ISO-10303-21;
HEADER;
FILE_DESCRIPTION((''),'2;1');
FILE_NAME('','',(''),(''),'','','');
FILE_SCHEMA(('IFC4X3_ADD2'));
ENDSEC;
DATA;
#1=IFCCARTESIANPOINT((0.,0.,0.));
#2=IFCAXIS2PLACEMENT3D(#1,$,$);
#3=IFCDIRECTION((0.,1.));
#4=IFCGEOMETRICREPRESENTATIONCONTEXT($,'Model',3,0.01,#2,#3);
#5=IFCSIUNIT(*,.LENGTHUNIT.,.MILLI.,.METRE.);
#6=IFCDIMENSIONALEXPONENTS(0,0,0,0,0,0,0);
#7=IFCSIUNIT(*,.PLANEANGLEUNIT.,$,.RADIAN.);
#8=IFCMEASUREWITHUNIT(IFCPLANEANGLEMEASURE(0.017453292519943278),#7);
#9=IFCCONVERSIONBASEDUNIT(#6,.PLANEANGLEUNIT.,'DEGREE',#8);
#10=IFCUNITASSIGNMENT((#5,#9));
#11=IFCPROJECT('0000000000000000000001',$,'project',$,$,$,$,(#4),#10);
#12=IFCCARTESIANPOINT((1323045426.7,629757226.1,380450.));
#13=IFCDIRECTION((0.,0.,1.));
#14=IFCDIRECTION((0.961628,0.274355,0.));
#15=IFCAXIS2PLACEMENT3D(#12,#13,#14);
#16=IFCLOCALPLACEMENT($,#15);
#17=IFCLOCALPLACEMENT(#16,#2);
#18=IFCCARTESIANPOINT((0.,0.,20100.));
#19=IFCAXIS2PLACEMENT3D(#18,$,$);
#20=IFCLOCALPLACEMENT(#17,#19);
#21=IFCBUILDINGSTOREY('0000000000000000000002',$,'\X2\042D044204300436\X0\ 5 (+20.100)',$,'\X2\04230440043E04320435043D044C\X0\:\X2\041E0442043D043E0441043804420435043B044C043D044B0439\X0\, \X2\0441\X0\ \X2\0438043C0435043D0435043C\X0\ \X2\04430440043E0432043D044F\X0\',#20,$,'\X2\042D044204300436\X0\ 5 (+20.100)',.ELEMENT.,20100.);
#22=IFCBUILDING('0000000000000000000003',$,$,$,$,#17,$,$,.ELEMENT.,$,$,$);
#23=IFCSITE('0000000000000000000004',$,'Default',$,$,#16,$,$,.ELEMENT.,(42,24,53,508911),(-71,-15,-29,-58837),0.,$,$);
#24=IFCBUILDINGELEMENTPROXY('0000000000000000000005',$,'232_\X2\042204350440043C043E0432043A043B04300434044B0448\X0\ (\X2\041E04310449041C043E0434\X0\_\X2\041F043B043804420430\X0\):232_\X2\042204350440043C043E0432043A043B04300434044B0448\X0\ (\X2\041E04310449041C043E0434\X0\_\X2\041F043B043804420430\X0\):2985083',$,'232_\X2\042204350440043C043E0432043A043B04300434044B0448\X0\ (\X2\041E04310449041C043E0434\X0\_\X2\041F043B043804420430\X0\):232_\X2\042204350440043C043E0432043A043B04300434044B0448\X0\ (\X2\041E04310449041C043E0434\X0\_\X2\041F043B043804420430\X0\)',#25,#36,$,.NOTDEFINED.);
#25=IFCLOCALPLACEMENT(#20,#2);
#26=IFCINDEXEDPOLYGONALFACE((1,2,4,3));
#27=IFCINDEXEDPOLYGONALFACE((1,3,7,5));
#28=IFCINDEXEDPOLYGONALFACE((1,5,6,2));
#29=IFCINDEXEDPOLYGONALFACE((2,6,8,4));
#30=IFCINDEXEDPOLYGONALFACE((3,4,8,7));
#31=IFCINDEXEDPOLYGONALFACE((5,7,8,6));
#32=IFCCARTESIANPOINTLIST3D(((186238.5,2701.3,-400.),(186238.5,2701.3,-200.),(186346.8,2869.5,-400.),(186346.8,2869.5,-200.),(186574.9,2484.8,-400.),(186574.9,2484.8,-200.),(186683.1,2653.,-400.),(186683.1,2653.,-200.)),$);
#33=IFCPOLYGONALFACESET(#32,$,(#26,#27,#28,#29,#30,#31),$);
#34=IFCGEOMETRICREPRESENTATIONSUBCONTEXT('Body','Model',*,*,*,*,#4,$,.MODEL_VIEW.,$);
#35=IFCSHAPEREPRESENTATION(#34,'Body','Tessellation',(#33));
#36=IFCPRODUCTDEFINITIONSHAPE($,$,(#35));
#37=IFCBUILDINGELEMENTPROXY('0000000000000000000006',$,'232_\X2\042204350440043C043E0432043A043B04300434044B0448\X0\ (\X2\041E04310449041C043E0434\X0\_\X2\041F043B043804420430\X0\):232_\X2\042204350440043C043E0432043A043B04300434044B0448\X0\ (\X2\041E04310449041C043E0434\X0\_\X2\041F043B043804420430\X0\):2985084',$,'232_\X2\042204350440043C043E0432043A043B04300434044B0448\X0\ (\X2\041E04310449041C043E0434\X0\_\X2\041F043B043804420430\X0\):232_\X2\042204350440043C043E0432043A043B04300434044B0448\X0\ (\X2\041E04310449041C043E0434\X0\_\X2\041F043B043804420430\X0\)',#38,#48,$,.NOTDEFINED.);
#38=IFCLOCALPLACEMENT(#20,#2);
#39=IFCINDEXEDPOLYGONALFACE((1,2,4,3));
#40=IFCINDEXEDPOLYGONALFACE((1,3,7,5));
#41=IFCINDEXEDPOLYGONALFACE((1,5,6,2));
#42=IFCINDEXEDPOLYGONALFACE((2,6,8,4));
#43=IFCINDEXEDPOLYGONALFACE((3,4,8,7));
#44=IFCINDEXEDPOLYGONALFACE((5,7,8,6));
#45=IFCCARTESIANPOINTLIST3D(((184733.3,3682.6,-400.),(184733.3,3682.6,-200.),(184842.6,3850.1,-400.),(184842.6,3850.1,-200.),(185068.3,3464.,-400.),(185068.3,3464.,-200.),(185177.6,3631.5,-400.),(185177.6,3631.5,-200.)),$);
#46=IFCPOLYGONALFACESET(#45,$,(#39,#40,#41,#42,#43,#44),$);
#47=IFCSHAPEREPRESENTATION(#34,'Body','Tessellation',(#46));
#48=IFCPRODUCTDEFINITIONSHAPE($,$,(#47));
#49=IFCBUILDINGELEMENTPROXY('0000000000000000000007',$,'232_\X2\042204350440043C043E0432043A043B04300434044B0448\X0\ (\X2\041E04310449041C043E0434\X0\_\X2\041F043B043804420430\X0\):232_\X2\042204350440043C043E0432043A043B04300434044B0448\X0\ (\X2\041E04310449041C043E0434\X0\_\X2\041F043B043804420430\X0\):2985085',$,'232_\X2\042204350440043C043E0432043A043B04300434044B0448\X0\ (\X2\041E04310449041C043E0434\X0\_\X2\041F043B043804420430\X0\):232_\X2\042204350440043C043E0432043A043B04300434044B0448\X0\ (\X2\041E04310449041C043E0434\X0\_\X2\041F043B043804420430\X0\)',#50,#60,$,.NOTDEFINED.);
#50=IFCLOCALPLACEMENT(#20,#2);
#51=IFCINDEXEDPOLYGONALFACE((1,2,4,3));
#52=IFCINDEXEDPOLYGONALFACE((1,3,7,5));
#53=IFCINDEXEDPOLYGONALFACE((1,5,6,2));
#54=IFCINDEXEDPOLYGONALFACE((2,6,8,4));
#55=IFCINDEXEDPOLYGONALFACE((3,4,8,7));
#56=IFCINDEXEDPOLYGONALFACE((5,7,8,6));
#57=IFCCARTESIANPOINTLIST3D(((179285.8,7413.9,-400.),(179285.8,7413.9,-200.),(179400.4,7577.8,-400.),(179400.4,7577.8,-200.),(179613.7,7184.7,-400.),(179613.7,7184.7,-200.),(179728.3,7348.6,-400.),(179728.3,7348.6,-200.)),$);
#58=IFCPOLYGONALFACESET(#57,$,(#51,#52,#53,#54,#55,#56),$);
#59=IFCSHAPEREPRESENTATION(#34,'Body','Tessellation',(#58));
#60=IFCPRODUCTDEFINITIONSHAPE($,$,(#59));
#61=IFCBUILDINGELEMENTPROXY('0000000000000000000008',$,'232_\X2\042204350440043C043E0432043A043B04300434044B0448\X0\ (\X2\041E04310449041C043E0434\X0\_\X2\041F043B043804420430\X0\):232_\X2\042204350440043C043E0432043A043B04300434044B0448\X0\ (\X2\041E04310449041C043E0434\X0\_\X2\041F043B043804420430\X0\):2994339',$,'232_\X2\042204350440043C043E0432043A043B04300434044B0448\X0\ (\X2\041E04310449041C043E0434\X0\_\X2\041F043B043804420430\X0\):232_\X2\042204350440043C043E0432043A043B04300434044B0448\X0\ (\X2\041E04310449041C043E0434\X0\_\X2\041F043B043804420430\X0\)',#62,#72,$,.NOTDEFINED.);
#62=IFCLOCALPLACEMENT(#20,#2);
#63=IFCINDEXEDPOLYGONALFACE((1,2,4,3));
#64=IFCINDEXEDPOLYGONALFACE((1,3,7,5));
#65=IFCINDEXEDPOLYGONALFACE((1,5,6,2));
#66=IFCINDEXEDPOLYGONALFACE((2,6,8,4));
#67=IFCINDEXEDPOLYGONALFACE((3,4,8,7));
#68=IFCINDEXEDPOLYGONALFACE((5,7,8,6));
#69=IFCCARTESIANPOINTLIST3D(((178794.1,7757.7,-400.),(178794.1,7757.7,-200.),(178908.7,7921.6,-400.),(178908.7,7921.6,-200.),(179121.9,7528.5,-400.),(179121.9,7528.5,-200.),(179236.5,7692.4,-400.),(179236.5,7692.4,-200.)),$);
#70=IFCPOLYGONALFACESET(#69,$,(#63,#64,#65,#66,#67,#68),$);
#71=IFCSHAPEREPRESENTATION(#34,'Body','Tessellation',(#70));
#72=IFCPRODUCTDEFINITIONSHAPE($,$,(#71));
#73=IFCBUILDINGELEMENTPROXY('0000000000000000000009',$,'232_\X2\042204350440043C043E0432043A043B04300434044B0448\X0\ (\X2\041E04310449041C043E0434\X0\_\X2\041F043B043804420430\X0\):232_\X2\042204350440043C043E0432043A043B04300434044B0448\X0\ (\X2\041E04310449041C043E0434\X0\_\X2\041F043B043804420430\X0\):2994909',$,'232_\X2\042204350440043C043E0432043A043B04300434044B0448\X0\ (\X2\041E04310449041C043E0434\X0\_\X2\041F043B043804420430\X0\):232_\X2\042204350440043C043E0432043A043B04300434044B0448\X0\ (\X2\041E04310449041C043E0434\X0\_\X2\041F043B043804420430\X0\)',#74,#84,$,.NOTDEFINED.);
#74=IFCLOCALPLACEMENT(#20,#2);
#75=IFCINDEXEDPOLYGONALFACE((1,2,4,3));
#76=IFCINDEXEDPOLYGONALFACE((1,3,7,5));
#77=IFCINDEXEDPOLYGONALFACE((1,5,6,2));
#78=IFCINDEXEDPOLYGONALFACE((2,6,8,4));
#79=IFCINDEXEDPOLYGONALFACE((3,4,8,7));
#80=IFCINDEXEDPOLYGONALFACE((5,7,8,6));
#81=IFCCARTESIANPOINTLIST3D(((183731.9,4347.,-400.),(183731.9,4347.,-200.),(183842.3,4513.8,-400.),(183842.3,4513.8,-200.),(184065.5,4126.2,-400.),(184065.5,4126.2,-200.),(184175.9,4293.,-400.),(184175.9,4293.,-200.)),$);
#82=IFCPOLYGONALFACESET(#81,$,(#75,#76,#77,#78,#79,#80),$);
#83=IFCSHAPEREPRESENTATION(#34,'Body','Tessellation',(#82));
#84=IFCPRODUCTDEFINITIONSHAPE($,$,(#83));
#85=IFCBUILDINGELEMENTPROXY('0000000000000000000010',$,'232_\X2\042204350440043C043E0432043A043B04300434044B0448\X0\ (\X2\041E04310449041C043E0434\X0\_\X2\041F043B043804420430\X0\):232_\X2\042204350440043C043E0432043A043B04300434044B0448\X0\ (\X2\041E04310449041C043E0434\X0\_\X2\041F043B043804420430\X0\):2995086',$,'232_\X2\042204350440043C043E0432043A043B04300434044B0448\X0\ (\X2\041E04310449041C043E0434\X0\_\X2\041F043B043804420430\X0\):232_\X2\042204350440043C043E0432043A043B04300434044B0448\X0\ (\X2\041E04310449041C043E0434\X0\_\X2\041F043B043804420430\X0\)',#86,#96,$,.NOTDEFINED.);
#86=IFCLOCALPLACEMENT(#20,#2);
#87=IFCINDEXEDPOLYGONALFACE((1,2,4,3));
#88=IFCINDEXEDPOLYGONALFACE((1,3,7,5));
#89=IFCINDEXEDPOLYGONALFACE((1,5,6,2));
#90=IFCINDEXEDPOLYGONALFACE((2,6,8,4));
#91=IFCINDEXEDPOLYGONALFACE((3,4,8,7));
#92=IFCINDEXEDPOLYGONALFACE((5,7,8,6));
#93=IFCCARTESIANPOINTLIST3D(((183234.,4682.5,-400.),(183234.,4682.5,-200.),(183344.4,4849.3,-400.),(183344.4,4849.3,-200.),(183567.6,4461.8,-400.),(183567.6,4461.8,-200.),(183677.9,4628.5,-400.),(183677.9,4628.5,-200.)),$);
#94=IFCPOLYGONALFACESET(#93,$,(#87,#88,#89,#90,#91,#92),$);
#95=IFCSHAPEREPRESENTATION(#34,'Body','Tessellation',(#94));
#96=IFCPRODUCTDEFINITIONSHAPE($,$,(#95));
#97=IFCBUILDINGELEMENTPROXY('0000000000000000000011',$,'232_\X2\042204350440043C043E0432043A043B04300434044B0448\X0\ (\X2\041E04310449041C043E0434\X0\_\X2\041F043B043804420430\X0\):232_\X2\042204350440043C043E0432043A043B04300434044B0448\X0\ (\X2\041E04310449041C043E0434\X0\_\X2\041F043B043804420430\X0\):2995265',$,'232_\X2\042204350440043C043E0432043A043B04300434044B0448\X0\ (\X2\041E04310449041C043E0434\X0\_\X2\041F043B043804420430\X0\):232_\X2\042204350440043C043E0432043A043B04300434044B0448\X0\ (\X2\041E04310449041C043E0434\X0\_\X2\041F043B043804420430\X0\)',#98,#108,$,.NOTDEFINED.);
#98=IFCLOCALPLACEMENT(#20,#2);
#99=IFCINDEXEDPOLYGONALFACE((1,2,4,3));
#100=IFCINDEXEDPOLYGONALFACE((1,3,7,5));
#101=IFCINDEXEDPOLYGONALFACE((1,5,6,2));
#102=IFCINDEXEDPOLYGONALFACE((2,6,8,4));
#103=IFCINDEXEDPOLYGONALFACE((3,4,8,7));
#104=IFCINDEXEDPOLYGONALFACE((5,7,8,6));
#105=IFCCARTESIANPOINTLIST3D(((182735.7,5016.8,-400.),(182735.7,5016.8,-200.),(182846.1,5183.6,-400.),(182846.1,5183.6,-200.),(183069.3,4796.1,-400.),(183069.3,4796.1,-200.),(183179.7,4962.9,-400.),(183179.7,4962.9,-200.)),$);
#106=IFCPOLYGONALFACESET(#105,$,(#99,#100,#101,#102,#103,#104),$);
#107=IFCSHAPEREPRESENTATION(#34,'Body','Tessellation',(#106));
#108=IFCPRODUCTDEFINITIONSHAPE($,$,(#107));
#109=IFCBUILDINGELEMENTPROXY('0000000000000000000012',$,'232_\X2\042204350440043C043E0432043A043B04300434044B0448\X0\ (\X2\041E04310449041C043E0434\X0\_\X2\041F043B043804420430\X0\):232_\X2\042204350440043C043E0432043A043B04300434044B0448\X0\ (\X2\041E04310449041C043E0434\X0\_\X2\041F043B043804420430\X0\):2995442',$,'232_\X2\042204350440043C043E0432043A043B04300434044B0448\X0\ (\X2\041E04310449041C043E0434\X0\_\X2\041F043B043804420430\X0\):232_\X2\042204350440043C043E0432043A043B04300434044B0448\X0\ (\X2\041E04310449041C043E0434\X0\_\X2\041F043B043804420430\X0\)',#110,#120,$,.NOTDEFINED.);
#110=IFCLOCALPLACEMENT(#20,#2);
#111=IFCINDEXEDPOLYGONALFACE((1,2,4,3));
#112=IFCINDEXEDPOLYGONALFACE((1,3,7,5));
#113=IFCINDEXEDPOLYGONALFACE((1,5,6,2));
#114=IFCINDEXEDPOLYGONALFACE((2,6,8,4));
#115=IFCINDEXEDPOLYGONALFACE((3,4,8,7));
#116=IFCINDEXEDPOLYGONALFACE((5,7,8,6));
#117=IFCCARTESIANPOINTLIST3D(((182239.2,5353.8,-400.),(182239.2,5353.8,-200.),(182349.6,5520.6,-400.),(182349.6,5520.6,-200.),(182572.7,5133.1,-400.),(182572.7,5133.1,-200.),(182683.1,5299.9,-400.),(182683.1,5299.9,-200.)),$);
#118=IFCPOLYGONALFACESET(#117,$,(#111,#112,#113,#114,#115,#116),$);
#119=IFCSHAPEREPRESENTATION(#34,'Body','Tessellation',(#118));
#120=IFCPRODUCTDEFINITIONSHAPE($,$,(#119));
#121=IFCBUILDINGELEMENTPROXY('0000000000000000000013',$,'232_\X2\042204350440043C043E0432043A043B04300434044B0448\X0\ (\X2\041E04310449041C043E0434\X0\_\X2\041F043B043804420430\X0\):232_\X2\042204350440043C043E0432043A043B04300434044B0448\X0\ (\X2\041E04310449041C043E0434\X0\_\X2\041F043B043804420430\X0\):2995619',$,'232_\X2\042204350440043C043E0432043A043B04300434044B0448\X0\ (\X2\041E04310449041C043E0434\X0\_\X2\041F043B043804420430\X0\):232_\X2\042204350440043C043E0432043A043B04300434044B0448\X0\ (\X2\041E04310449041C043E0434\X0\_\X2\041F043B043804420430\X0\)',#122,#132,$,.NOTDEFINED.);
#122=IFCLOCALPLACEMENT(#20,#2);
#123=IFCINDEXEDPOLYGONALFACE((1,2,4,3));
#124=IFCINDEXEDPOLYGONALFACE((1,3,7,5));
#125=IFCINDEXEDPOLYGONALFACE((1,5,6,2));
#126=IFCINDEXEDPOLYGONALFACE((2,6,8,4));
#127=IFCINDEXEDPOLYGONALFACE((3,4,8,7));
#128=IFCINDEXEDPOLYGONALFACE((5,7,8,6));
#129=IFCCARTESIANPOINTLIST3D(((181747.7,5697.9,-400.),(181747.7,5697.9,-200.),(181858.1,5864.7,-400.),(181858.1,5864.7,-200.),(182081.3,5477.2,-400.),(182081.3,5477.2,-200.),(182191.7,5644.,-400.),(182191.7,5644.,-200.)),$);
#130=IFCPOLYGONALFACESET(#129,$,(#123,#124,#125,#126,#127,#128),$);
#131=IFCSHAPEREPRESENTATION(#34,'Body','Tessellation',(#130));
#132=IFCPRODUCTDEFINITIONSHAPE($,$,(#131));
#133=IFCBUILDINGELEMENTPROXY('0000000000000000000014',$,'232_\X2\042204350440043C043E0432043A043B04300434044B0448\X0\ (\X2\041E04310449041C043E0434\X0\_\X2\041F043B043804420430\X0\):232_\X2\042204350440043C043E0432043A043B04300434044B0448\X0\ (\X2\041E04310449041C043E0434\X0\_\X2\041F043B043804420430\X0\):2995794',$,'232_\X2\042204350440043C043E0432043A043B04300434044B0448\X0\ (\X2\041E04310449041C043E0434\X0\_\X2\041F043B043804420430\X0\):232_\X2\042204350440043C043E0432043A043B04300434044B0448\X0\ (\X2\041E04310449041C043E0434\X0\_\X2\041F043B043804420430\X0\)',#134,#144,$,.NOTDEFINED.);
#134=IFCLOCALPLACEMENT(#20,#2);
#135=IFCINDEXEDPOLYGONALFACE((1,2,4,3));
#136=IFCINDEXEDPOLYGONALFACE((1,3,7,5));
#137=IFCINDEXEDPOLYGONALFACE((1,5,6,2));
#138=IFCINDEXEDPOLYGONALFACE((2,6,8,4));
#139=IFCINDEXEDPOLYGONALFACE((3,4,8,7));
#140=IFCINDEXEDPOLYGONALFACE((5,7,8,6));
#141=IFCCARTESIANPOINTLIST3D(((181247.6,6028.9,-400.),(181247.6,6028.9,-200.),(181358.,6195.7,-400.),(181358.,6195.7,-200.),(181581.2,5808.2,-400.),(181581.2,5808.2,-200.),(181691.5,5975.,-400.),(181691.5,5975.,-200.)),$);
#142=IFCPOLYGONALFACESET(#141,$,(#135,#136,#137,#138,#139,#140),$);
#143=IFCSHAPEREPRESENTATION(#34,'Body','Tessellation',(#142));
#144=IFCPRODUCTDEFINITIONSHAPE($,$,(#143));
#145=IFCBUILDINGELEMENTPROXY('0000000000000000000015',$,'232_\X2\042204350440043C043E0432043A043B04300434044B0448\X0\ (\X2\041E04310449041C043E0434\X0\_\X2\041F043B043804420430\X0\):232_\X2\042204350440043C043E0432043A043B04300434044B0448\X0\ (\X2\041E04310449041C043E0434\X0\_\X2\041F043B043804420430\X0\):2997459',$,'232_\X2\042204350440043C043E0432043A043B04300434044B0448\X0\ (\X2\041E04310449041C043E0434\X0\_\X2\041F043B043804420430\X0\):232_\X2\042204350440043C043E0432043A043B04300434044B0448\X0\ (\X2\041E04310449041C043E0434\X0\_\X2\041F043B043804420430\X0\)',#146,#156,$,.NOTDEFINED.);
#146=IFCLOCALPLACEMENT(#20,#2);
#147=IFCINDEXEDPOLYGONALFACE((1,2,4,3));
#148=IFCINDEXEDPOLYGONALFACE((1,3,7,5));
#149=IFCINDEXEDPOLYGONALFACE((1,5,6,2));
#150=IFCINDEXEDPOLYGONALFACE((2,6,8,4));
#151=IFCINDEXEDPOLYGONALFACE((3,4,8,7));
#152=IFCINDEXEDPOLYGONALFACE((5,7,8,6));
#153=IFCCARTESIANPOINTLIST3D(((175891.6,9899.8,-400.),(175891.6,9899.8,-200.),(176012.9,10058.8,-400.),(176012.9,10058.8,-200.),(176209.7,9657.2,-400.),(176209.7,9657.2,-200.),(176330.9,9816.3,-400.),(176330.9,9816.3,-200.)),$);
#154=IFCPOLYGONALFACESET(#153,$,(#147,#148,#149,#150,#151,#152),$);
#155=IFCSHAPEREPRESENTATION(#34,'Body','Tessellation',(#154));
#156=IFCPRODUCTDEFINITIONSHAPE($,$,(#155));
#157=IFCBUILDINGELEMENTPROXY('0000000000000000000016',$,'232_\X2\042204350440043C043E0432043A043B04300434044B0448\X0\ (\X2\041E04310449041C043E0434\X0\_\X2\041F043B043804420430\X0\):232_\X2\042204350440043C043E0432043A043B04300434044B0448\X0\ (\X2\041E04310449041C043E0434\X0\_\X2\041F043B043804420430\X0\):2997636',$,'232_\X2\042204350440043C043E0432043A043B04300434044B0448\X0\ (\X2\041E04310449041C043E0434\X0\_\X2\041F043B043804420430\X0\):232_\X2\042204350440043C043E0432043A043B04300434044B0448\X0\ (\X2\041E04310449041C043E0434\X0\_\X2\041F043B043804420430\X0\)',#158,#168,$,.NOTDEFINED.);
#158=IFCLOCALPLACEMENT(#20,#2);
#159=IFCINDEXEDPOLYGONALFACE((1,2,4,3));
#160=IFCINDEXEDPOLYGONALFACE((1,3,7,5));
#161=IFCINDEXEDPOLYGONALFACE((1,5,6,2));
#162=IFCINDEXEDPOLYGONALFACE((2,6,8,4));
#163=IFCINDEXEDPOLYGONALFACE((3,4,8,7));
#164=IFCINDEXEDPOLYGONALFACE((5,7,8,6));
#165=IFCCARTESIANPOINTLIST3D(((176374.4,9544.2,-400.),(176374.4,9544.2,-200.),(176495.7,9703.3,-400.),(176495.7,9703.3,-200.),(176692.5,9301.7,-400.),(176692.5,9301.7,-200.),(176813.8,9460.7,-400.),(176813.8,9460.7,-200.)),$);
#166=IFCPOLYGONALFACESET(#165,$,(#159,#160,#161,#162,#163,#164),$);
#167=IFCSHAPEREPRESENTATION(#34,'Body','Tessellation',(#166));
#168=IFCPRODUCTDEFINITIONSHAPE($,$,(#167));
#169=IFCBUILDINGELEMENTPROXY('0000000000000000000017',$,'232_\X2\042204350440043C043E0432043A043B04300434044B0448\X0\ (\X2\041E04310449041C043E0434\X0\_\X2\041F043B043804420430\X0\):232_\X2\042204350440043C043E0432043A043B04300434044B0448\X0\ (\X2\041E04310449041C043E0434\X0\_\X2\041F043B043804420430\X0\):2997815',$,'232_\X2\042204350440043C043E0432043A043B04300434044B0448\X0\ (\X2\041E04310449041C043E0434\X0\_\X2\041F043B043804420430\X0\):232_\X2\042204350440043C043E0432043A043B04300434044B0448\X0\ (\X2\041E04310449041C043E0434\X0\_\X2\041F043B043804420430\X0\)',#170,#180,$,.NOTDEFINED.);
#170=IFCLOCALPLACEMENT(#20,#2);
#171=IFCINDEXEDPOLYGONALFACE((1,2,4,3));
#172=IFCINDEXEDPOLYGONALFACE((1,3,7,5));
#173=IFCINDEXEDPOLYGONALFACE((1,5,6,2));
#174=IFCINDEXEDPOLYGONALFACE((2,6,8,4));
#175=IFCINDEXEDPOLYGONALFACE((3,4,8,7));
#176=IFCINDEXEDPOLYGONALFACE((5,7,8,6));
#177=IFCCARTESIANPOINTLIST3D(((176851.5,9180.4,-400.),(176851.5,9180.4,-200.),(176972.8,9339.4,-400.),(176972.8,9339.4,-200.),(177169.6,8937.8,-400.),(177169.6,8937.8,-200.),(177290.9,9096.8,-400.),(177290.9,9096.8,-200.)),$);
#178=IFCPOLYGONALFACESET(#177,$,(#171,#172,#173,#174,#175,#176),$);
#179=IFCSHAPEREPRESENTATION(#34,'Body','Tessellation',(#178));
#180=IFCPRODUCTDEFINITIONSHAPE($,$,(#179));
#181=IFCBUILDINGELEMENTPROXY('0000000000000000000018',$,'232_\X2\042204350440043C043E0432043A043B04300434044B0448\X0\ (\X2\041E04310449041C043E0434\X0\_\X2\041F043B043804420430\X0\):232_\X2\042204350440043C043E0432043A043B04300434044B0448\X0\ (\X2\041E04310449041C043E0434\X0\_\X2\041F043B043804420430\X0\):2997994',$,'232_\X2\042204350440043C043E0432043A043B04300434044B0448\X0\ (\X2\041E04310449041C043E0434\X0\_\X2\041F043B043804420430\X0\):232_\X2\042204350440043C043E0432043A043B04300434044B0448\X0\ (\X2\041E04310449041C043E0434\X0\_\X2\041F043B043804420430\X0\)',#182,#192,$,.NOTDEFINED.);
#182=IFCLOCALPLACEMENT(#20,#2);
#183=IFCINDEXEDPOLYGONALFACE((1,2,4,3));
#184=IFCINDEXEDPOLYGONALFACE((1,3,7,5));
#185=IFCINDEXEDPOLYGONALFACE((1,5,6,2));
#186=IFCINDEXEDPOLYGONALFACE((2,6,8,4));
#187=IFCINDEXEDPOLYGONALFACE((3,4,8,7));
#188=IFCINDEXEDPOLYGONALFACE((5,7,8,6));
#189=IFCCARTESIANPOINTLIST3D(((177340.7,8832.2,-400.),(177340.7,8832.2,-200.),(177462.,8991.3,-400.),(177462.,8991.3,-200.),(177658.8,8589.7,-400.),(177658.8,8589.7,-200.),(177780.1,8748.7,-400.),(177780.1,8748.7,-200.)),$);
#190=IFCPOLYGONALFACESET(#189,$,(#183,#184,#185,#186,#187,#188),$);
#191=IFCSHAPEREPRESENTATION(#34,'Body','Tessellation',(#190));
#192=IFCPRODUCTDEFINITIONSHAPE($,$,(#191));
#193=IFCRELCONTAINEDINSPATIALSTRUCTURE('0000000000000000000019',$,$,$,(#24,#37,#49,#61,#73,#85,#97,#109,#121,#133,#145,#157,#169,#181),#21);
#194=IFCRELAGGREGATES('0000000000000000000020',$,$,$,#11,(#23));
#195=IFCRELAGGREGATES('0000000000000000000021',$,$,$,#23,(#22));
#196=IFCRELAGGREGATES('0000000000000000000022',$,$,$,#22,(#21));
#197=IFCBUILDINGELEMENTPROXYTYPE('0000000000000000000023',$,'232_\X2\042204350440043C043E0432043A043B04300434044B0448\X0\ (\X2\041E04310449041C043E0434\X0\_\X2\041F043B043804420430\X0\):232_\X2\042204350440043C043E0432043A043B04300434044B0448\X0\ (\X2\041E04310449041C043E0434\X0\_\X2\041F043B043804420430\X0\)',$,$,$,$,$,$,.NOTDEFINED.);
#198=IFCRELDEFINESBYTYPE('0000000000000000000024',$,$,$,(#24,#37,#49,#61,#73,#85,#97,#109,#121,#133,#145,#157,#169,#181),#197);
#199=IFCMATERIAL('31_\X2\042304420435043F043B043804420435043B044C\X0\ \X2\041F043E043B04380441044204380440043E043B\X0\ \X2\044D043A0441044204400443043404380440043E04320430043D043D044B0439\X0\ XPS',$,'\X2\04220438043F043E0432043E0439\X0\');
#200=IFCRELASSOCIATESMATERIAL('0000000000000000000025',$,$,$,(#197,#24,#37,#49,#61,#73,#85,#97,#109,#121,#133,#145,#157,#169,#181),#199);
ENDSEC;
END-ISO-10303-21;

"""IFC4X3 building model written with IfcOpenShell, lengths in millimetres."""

from ifc_helpers import new_model, entity, si_unit, converted_unit, direction, frame, origin, origin_2d_with_axis, place, context, subcontext, project, spatial, rectangle, extrude, source, transform, mapped, material, type_object, type_shapes, element, save


model = new_model("IFC4X3")

# Units and contexts
model_context = context("Model", 3, precision=0.01, world=origin(), true_north=direction((0.0, 1.0)))
body_context = subcontext(model_context, "Body", "Model", "MODEL_VIEW")
ifc_project = project(units=[si_unit("LENGTHUNIT", "METRE", prefix="MILLI"), converted_unit("PLANEANGLEUNIT", "DEGREE", entity("IfcPlaneAngleMeasure", 0.017453292519943278), si_unit("PLANEANGLEUNIT", "RADIAN"), dimensions=[0, 0, 0, 0, 0, 0, 0])], contexts=[model_context])

# Site, building, storey
site_placement = place(None, frame((1323045426.7, 629757226.1, 380450.0), z_axis=(0.0, 0.0, 1.0), x_axis=(0.961628, 0.274355, 0.0)))
site = spatial("IfcSite", under=ifc_project, at=site_placement, Name="Default", CompositionType="ELEMENT", RefLatitude=(42, 24, 53, 508911), RefLongitude=(-71, -15, -29, -58837), RefElevation=0.0)
building_placement = place(site_placement, origin())
building = spatial("IfcBuilding", under=site, at=building_placement, CompositionType="ELEMENT")
storey_placement = place(building_placement, frame((0.0, 0.0, 20100.0)))
storey = spatial("IfcBuildingStorey", under=building, at=storey_placement, Name="Этаж 5 (+20.100)", ObjectType="Уровень:Относительный, с именем уровня", LongName="Этаж 5 (+20.100)", CompositionType="ELEMENT", Elevation=20100.0)

# Building element proxies
ifc_material = material(Name="31_Утеплитель Полистирол экструдированный XPS", Category="Типовой")
building_element_proxy_type_1 = type_object("IfcBuildingElementProxyType", Name="232_Термовкладыш (ОбщМод_Плита):232_Термовкладыш (ОбщМод_Плита)", PredefinedType="NOTDEFINED", material=ifc_material)
shared_shape_1 = source(origin(), body_context, "Body", "SweptSolid", [
    extrude(rectangle(XDim=400.0, YDim=200.0, at=origin_2d_with_axis()), frame((200.0, 0.0, -200.0), z_axis=(0.0, 0.0, 1.0), x_axis=(-1.0, 0.0, 0.0)), (0.0, 0.0, 1.0), 200.0),
])
type_shapes(building_element_proxy_type_1, [shared_shape_1])
for number, where, z_axis, x_axis, name in (
    (1, (186629.0, 2568.9, -200.0), (0.0, 0.0, 1.0), (-0.840884, 0.541216, 0.0), "232_Термовкладыш (ОбщМод_Плита):232_Термовкладыш (ОбщМод_Плита):2985083"),
    (2, (185122.9, 3547.7, -200.0), (0.0, 0.0, 1.0), (-0.837417, 0.546565, 0.0), "232_Термовкладыш (ОбщМод_Плита):232_Термовкладыш (ОбщМод_Плита):2985084"),
    (3, (179671.0, 7266.7, -200.0), (0.0, 0.0, 1.0), (-0.819574, 0.572973, 0.0), "232_Термовкладыш (ОбщМод_Плита):232_Термовкладыш (ОбщМод_Плита):2985085"),
    (4, (179179.2, 7610.4, -200.0), (0.0, 0.0, 1.0), (-0.819574, 0.572973, 0.0), "232_Термовкладыш (ОбщМод_Плита):232_Термовкладыш (ОбщМод_Плита):2994339"),
    (5, (184120.7, 4209.6, -200.0), (0.0, 0.0, 1.0), (-0.833916, 0.551892, 0.0), "232_Термовкладыш (ОбщМод_Плита):232_Термовкладыш (ОбщМод_Плита):2994909"),
    (6, (183622.7, 4545.1, -200.0), (0.0, 0.0, 1.0), (-0.833916, 0.551892, 0.0), "232_Термовкладыш (ОбщМод_Плита):232_Термовкладыш (ОбщМод_Плита):2995086"),
    (7, (183124.5, 4879.5, -200.0), (0.0, 0.0, 1.0), (-0.833916, 0.551892, 0.0), "232_Термовкладыш (ОбщМод_Плита):232_Термовкладыш (ОбщМод_Плита):2995265"),
    (8, (182627.9, 5216.5, -200.0), (0.0, 0.0, 1.0), (-0.833916, 0.551892, 0.0), "232_Термовкладыш (ОбщМод_Плита):232_Термовкладыш (ОбщМод_Плита):2995442"),
    (9, (182136.5, 5560.6, -200.0), (0.0, 0.0, 1.0), (-0.833916, 0.551892, 0.0), "232_Термовкладыш (ОбщМод_Плита):232_Термовкладыш (ОбщМод_Плита):2995619"),
    (10, (181636.4, 5891.6, -200.0), (0.0, 0.0, 1.0), (-0.833916, 0.551892, 0.0), "232_Термовкладыш (ОбщМод_Плита):232_Термовкладыш (ОбщМод_Плита):2995794"),
    (11, (176270.3, 9736.7, -200.0), (0.0, 0.0, 1.0), (-0.795137, 0.60643, 0.0), "232_Термовкладыш (ОбщМод_Плита):232_Термовкладыш (ОбщМод_Плита):2997459"),
    (12, (176753.1, 9381.2, -200.0), (0.0, 0.0, 1.0), (-0.795137, 0.60643, 0.0), "232_Термовкладыш (ОбщМод_Плита):232_Термовкладыш (ОбщМод_Плита):2997636"),
    (13, (177230.2, 9017.3, -200.0), (0.0, 0.0, 1.0), (-0.795137, 0.60643, 0.0), "232_Термовкладыш (ОбщМод_Плита):232_Термовкладыш (ОбщМод_Плита):2997815"),
    (14, (177719.4, 8669.2, -200.0), (0.0, 0.0, 1.0), (-0.795137, 0.60643, 0.0), "232_Термовкладыш (ОбщМод_Плита):232_Термовкладыш (ОбщМод_Плита):2997994"),
):
    element("IfcBuildingElementProxy", number, at=place(storey_placement, frame(where, z_axis=z_axis, x_axis=x_axis)), inside=storey, type_object=building_element_proxy_type_1, material=ifc_material, Name=name, ObjectType="232_Термовкладыш (ОбщМод_Плита):232_Термовкладыш (ОбщМод_Плита)", PredefinedType="NOTDEFINED", context=body_context, shape_type="MappedRepresentation", body=[
        mapped(shared_shape_1, transform((0.0, 0.0, 0.0), scale=1.0)),
    ])

save(model, "model.ifc")
